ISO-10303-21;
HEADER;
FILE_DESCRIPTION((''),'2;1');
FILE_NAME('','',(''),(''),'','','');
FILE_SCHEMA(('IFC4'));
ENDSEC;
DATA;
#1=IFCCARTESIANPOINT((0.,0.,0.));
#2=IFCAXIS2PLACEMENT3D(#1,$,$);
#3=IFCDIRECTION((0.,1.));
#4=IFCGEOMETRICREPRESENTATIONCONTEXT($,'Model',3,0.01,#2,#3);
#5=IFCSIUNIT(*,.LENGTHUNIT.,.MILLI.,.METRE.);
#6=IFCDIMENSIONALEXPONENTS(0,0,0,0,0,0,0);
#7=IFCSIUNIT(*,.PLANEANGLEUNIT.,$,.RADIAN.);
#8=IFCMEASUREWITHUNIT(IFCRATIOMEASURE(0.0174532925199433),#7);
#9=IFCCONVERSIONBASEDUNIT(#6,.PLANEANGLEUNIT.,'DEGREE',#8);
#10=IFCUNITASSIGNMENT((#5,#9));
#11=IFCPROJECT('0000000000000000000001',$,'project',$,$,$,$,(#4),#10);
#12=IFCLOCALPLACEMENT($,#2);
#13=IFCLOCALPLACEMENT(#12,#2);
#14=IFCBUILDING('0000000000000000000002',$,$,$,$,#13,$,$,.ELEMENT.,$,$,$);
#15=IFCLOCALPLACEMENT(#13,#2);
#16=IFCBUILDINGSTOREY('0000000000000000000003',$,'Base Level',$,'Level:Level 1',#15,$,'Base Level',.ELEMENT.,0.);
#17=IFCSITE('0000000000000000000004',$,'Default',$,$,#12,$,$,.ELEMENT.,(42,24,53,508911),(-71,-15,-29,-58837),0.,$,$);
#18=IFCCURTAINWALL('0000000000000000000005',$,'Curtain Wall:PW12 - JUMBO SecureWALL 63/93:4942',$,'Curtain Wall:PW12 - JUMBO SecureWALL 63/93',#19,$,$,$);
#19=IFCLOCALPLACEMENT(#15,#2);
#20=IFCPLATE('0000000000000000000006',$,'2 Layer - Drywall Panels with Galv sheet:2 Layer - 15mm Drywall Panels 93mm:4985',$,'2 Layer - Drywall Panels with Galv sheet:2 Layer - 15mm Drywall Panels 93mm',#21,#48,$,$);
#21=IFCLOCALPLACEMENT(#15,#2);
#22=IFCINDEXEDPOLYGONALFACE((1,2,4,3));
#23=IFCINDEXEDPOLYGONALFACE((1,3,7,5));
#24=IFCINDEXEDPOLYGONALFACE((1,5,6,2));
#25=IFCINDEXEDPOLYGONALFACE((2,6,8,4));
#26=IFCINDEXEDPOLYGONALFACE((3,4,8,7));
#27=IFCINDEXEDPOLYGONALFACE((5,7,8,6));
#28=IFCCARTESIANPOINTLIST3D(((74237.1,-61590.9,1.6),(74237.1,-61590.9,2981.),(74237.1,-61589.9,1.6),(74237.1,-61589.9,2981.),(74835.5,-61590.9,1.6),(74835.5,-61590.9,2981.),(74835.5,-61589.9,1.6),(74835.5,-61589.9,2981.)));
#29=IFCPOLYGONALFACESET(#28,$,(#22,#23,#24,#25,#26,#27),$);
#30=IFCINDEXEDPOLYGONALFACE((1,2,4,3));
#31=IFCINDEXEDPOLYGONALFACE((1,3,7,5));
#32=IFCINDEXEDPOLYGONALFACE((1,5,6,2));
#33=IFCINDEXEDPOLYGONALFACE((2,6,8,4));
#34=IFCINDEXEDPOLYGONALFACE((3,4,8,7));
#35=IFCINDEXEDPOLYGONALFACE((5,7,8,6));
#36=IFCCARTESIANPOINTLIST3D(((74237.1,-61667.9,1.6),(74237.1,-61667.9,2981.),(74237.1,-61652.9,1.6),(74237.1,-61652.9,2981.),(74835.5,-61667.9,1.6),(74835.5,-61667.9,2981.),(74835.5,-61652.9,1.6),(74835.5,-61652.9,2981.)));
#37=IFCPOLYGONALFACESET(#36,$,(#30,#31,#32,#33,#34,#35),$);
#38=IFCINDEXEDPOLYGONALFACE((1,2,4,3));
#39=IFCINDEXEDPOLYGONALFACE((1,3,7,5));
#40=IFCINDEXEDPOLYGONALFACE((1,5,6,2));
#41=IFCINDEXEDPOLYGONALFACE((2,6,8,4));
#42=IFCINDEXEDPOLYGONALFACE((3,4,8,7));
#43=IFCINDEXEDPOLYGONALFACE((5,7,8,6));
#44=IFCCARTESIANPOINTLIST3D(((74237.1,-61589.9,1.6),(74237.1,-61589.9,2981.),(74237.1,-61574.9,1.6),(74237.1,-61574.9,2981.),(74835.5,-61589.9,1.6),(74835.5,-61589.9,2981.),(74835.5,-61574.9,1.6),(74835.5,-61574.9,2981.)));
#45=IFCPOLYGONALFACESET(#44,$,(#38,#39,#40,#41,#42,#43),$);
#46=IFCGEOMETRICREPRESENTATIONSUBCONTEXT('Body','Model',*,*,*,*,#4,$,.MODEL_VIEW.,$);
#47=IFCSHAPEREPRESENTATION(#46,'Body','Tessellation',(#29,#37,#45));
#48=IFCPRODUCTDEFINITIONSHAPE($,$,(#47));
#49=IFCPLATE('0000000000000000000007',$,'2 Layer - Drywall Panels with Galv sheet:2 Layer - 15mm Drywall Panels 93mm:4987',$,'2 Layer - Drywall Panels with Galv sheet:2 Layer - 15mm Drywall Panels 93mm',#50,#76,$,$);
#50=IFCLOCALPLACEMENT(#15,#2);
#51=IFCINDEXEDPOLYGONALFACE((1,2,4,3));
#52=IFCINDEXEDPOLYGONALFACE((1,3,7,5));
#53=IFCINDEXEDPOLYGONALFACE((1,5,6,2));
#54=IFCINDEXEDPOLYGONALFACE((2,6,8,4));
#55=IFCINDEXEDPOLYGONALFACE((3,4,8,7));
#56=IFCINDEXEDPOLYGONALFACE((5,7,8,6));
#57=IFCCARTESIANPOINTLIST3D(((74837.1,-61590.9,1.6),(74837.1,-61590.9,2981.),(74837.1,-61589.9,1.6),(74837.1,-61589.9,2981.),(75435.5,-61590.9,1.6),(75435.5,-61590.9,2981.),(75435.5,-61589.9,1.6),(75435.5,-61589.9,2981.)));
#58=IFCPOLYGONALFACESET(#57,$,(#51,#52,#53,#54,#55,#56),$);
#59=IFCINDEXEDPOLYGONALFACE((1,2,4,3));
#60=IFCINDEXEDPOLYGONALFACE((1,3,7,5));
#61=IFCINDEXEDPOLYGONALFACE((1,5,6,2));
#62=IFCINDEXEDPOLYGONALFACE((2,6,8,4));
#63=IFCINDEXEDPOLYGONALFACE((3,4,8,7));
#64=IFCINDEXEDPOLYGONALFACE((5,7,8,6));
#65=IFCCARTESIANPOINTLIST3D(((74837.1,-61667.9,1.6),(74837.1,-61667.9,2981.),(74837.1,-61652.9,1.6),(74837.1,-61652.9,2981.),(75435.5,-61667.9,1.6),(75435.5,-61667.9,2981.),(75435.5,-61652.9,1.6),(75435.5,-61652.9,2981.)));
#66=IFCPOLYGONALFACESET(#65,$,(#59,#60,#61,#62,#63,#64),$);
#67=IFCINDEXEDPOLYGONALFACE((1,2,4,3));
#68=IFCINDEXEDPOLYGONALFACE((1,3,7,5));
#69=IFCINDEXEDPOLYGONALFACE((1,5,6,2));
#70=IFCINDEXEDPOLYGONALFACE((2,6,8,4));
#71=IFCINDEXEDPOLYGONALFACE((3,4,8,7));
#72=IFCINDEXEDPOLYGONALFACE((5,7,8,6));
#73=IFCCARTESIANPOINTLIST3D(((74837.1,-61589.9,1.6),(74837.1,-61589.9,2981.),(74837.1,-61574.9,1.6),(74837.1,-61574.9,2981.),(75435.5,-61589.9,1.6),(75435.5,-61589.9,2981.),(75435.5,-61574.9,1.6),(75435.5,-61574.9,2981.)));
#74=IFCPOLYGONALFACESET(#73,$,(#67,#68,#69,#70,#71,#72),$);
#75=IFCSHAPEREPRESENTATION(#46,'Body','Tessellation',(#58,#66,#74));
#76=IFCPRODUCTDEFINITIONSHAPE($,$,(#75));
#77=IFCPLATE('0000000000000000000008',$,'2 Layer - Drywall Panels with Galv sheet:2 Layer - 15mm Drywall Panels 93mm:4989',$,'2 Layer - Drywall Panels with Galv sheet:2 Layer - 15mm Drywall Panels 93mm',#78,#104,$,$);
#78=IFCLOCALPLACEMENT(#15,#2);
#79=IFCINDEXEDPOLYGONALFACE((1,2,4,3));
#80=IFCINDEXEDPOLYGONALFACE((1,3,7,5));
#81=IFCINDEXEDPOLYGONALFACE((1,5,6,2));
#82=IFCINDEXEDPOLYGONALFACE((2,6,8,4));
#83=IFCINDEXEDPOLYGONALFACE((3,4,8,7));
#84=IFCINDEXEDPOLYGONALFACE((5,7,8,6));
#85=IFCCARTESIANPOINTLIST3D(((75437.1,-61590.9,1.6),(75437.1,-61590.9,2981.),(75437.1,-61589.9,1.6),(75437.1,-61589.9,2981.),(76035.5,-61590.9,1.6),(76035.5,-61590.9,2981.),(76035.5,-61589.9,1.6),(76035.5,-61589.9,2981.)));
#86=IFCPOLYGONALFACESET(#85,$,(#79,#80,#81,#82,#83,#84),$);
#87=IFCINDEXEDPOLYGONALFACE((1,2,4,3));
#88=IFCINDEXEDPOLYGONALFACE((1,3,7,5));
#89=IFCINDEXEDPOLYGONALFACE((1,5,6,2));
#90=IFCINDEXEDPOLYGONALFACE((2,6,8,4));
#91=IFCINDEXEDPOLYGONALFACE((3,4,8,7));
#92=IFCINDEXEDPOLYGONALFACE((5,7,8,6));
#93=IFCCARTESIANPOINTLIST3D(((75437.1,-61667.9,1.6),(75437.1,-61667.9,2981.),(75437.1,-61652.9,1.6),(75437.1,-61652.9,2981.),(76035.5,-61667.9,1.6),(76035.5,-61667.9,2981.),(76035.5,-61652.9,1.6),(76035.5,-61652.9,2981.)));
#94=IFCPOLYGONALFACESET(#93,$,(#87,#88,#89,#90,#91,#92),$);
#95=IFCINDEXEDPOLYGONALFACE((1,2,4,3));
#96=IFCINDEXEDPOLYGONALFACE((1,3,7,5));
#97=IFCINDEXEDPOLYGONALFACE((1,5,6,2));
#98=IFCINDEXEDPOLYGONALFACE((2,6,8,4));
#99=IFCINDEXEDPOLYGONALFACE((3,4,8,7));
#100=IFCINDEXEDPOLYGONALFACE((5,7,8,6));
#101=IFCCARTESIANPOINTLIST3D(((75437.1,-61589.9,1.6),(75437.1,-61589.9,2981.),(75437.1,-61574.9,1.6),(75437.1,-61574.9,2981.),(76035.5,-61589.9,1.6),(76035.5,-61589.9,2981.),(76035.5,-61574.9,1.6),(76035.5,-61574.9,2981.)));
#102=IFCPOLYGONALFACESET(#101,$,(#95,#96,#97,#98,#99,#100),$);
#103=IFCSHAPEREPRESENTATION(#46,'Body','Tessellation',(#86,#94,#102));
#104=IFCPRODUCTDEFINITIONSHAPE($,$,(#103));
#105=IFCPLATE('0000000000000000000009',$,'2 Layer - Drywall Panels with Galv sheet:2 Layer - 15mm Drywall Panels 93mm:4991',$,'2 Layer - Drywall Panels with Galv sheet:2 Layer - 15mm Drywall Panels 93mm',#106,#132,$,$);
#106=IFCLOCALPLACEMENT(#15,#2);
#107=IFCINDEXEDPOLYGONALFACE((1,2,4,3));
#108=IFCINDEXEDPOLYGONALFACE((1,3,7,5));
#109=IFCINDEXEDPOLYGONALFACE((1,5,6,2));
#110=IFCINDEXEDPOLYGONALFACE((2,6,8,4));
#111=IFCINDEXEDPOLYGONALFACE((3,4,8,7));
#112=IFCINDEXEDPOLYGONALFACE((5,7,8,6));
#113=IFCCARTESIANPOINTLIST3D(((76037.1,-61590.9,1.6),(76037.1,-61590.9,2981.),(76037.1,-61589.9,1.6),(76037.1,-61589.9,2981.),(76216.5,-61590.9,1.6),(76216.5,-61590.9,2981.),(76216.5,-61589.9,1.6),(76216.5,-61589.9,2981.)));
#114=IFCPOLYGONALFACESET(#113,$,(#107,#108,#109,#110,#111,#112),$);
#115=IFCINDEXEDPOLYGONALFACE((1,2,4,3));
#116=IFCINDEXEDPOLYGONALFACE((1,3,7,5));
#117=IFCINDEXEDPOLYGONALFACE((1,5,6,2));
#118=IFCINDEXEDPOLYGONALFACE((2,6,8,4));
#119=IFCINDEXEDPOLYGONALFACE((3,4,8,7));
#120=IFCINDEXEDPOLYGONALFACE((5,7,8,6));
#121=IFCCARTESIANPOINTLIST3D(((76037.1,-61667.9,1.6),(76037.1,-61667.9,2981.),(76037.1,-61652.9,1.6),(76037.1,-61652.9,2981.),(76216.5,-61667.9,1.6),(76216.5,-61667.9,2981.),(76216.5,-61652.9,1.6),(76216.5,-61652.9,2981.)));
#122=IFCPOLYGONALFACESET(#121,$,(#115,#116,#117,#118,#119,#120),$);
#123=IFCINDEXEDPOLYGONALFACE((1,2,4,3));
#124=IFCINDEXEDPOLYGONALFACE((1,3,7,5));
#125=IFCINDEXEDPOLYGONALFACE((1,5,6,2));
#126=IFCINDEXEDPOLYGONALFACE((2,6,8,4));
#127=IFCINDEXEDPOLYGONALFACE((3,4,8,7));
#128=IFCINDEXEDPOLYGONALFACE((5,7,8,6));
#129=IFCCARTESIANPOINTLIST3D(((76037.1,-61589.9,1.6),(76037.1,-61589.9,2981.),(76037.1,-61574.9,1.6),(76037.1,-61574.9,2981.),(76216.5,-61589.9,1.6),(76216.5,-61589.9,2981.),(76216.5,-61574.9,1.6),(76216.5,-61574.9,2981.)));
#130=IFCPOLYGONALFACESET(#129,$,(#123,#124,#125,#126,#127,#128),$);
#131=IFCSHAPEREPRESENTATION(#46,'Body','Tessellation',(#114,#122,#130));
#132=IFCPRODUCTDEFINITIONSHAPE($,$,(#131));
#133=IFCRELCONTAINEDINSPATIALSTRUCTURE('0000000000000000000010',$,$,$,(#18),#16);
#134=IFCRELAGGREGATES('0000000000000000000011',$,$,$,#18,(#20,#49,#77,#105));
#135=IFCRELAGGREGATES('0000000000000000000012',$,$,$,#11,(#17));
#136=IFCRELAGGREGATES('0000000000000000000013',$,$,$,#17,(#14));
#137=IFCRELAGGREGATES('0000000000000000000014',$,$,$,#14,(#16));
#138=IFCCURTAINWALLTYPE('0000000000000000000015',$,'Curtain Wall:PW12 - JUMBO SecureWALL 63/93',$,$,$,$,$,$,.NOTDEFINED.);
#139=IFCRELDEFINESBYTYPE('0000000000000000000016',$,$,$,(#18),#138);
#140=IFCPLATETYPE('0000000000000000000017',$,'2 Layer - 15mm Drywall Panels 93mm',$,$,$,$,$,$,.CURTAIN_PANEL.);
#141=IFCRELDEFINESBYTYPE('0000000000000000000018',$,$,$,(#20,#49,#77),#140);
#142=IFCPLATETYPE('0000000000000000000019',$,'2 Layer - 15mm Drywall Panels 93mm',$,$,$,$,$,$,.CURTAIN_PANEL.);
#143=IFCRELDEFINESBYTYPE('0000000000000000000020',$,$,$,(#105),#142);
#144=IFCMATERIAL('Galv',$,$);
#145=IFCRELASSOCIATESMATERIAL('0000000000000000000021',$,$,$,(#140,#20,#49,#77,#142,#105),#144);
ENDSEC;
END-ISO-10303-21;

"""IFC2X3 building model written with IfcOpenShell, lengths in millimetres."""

from ifc_helpers import new_model, entity, si_unit, converted_unit, direction, frame, frame_2d, origin, origin_2d_with_axis, place, context, subcontext, project, spatial, rectangle, extrude, source, transform, mapped, material, type_object, type_shapes, element, aggregate, save


model = new_model("IFC2X3")

# Units and contexts
model_context = context("Model", 3, precision=0.01, world=origin(), true_north=direction((0.0, 1.0)))
body_context = subcontext(model_context, "Body", "Model", "MODEL_VIEW")
ifc_project = project(units=[si_unit("LENGTHUNIT", "METRE", prefix="MILLI"), converted_unit("PLANEANGLEUNIT", "DEGREE", entity("IfcRatioMeasure", 0.0174532925199433), si_unit("PLANEANGLEUNIT", "RADIAN"), dimensions=[0, 0, 0, 0, 0, 0, 0])], contexts=[model_context])

# Site, building, storey
site_placement = place(None, origin())
site = spatial("IfcSite", under=ifc_project, at=site_placement, Name="Default", CompositionType="ELEMENT", RefLatitude=(42, 24, 53, 508911), RefLongitude=(-71, -15, -29, -58837), RefElevation=0.0)
building_placement = place(site_placement, origin())
building = spatial("IfcBuilding", under=site, at=building_placement, CompositionType="ELEMENT")
storey_placement = place(building_placement, origin())
storey = spatial("IfcBuildingStorey", under=building, at=storey_placement, Name="Base Level", ObjectType="Level:Level 1", LongName="Base Level", CompositionType="ELEMENT", Elevation=0.0)

# Curtain wall, plates
curtain_wall_type = type_object("IfcCurtainWallType", Name="Curtain Wall:PW12 - JUMBO SecureWALL 63/93", PredefinedType="NOTDEFINED")
curtain_wall_placement = place(building_placement, origin())
curtain_wall = element("IfcCurtainWall", 1, at=curtain_wall_placement, inside=storey, type_object=curtain_wall_type, Name="Curtain Wall:PW12 - JUMBO SecureWALL 63/93:4942", ObjectType="Curtain Wall:PW12 - JUMBO SecureWALL 63/93")
ifc_material_1 = material(Name="Galv")
plate_type_1 = type_object("IfcPlateType", Name="2 Layer - 15mm Drywall Panels 93mm", PredefinedType="CURTAIN_PANEL", material=ifc_material_1)
shared_shape_1 = source(origin(), body_context, "Body", "SweptSolid", [
    extrude(rectangle(XDim=598.4, YDim=1.0, at=origin_2d_with_axis()), frame((0.0, 31.0, 0.0), z_axis=(0.0, 0.0, 1.0), x_axis=(-1.0, 0.0, 0.0)), (0.0, 0.0, 1.0), 2979.4),
    extrude(rectangle(XDim=598.4, YDim=15.0, at=frame_2d((0.0, 0.0), x_axis=(1.0, 0.0))), frame((0.0, -39.0, 0.0), z_axis=(0.0, 0.0, 1.0), x_axis=(-1.0, 0.0, 0.0)), (0.0, 0.0, 1.0), 2979.4),
    extrude(rectangle(XDim=15.0, YDim=598.4, at=frame_2d((0.0, 0.0), x_axis=(1.0, 0.0))), frame((0.0, 39.0, 0.0), z_axis=(0.0, 0.0, 1.0), x_axis=(0.0, 1.0, 0.0)), (0.0, 0.0, 1.0), 2979.4),
])
type_shapes(plate_type_1, [shared_shape_1])
plate_1_placement = place(curtain_wall_placement, frame((74536.3, -61621.4, 1.6)))
plate_1 = element("IfcPlate", 2, at=plate_1_placement, type_object=plate_type_1, material=ifc_material_1, Name="2 Layer - Drywall Panels with Galv sheet:2 Layer - 15mm Drywall Panels 93mm:4985", ObjectType="2 Layer - Drywall Panels with Galv sheet:2 Layer - 15mm Drywall Panels 93mm", context=body_context, shape_type="MappedRepresentation", body=[
    mapped(shared_shape_1, transform((0.0, 0.0, 0.0), scale=1.0)),
])
plate_2_placement = place(curtain_wall_placement, frame((75136.3, -61621.4, 1.6)))
plate_2 = element("IfcPlate", 3, at=plate_2_placement, type_object=plate_type_1, material=ifc_material_1, Name="2 Layer - Drywall Panels with Galv sheet:2 Layer - 15mm Drywall Panels 93mm:4987", ObjectType="2 Layer - Drywall Panels with Galv sheet:2 Layer - 15mm Drywall Panels 93mm", context=body_context, shape_type="MappedRepresentation", body=[
    mapped(shared_shape_1, transform((0.0, 0.0, 0.0), scale=1.0)),
])
plate_3_placement = place(curtain_wall_placement, frame((75736.3, -61621.4, 1.6)))
plate_3 = element("IfcPlate", 4, at=plate_3_placement, type_object=plate_type_1, material=ifc_material_1, Name="2 Layer - Drywall Panels with Galv sheet:2 Layer - 15mm Drywall Panels 93mm:4989", ObjectType="2 Layer - Drywall Panels with Galv sheet:2 Layer - 15mm Drywall Panels 93mm", context=body_context, shape_type="MappedRepresentation", body=[
    mapped(shared_shape_1, transform((0.0, 0.0, 0.0), scale=1.0)),
])
plate_type_2 = type_object("IfcPlateType", Name="2 Layer - 15mm Drywall Panels 93mm", PredefinedType="CURTAIN_PANEL", material=ifc_material_1)
shared_shape_2 = source(origin(), body_context, "Body", "SweptSolid", [
    extrude(rectangle(XDim=179.4, YDim=1.0, at=origin_2d_with_axis()), frame((0.0, 31.0, 0.0), z_axis=(0.0, 0.0, 1.0), x_axis=(-1.0, 0.0, 0.0)), (0.0, 0.0, 1.0), 2979.4),
    extrude(rectangle(XDim=179.4, YDim=15.0, at=frame_2d((0.0, 0.0), x_axis=(1.0, 0.0))), frame((0.0, -39.0, 0.0), z_axis=(0.0, 0.0, 1.0), x_axis=(-1.0, 0.0, 0.0)), (0.0, 0.0, 1.0), 2979.4),
    extrude(rectangle(XDim=15.0, YDim=179.4, at=frame_2d((0.0, 0.0), x_axis=(1.0, 0.0))), frame((0.0, 39.0, 0.0), z_axis=(0.0, 0.0, 1.0), x_axis=(0.0, 1.0, 0.0)), (0.0, 0.0, 1.0), 2979.4),
])
type_shapes(plate_type_2, [shared_shape_2])
plate_4_placement = place(curtain_wall_placement, frame((76126.8, -61621.4, 1.6)))
plate_4 = element("IfcPlate", 5, at=plate_4_placement, type_object=plate_type_2, material=ifc_material_1, Name="2 Layer - Drywall Panels with Galv sheet:2 Layer - 15mm Drywall Panels 93mm:4991", ObjectType="2 Layer - Drywall Panels with Galv sheet:2 Layer - 15mm Drywall Panels 93mm", context=body_context, shape_type="MappedRepresentation", body=[
    mapped(shared_shape_2, transform((0.0, 0.0, 0.0), scale=1.0)),
])
aggregate(curtain_wall, [plate_1, plate_2, plate_3, plate_4])

save(model, "model.ifc")
